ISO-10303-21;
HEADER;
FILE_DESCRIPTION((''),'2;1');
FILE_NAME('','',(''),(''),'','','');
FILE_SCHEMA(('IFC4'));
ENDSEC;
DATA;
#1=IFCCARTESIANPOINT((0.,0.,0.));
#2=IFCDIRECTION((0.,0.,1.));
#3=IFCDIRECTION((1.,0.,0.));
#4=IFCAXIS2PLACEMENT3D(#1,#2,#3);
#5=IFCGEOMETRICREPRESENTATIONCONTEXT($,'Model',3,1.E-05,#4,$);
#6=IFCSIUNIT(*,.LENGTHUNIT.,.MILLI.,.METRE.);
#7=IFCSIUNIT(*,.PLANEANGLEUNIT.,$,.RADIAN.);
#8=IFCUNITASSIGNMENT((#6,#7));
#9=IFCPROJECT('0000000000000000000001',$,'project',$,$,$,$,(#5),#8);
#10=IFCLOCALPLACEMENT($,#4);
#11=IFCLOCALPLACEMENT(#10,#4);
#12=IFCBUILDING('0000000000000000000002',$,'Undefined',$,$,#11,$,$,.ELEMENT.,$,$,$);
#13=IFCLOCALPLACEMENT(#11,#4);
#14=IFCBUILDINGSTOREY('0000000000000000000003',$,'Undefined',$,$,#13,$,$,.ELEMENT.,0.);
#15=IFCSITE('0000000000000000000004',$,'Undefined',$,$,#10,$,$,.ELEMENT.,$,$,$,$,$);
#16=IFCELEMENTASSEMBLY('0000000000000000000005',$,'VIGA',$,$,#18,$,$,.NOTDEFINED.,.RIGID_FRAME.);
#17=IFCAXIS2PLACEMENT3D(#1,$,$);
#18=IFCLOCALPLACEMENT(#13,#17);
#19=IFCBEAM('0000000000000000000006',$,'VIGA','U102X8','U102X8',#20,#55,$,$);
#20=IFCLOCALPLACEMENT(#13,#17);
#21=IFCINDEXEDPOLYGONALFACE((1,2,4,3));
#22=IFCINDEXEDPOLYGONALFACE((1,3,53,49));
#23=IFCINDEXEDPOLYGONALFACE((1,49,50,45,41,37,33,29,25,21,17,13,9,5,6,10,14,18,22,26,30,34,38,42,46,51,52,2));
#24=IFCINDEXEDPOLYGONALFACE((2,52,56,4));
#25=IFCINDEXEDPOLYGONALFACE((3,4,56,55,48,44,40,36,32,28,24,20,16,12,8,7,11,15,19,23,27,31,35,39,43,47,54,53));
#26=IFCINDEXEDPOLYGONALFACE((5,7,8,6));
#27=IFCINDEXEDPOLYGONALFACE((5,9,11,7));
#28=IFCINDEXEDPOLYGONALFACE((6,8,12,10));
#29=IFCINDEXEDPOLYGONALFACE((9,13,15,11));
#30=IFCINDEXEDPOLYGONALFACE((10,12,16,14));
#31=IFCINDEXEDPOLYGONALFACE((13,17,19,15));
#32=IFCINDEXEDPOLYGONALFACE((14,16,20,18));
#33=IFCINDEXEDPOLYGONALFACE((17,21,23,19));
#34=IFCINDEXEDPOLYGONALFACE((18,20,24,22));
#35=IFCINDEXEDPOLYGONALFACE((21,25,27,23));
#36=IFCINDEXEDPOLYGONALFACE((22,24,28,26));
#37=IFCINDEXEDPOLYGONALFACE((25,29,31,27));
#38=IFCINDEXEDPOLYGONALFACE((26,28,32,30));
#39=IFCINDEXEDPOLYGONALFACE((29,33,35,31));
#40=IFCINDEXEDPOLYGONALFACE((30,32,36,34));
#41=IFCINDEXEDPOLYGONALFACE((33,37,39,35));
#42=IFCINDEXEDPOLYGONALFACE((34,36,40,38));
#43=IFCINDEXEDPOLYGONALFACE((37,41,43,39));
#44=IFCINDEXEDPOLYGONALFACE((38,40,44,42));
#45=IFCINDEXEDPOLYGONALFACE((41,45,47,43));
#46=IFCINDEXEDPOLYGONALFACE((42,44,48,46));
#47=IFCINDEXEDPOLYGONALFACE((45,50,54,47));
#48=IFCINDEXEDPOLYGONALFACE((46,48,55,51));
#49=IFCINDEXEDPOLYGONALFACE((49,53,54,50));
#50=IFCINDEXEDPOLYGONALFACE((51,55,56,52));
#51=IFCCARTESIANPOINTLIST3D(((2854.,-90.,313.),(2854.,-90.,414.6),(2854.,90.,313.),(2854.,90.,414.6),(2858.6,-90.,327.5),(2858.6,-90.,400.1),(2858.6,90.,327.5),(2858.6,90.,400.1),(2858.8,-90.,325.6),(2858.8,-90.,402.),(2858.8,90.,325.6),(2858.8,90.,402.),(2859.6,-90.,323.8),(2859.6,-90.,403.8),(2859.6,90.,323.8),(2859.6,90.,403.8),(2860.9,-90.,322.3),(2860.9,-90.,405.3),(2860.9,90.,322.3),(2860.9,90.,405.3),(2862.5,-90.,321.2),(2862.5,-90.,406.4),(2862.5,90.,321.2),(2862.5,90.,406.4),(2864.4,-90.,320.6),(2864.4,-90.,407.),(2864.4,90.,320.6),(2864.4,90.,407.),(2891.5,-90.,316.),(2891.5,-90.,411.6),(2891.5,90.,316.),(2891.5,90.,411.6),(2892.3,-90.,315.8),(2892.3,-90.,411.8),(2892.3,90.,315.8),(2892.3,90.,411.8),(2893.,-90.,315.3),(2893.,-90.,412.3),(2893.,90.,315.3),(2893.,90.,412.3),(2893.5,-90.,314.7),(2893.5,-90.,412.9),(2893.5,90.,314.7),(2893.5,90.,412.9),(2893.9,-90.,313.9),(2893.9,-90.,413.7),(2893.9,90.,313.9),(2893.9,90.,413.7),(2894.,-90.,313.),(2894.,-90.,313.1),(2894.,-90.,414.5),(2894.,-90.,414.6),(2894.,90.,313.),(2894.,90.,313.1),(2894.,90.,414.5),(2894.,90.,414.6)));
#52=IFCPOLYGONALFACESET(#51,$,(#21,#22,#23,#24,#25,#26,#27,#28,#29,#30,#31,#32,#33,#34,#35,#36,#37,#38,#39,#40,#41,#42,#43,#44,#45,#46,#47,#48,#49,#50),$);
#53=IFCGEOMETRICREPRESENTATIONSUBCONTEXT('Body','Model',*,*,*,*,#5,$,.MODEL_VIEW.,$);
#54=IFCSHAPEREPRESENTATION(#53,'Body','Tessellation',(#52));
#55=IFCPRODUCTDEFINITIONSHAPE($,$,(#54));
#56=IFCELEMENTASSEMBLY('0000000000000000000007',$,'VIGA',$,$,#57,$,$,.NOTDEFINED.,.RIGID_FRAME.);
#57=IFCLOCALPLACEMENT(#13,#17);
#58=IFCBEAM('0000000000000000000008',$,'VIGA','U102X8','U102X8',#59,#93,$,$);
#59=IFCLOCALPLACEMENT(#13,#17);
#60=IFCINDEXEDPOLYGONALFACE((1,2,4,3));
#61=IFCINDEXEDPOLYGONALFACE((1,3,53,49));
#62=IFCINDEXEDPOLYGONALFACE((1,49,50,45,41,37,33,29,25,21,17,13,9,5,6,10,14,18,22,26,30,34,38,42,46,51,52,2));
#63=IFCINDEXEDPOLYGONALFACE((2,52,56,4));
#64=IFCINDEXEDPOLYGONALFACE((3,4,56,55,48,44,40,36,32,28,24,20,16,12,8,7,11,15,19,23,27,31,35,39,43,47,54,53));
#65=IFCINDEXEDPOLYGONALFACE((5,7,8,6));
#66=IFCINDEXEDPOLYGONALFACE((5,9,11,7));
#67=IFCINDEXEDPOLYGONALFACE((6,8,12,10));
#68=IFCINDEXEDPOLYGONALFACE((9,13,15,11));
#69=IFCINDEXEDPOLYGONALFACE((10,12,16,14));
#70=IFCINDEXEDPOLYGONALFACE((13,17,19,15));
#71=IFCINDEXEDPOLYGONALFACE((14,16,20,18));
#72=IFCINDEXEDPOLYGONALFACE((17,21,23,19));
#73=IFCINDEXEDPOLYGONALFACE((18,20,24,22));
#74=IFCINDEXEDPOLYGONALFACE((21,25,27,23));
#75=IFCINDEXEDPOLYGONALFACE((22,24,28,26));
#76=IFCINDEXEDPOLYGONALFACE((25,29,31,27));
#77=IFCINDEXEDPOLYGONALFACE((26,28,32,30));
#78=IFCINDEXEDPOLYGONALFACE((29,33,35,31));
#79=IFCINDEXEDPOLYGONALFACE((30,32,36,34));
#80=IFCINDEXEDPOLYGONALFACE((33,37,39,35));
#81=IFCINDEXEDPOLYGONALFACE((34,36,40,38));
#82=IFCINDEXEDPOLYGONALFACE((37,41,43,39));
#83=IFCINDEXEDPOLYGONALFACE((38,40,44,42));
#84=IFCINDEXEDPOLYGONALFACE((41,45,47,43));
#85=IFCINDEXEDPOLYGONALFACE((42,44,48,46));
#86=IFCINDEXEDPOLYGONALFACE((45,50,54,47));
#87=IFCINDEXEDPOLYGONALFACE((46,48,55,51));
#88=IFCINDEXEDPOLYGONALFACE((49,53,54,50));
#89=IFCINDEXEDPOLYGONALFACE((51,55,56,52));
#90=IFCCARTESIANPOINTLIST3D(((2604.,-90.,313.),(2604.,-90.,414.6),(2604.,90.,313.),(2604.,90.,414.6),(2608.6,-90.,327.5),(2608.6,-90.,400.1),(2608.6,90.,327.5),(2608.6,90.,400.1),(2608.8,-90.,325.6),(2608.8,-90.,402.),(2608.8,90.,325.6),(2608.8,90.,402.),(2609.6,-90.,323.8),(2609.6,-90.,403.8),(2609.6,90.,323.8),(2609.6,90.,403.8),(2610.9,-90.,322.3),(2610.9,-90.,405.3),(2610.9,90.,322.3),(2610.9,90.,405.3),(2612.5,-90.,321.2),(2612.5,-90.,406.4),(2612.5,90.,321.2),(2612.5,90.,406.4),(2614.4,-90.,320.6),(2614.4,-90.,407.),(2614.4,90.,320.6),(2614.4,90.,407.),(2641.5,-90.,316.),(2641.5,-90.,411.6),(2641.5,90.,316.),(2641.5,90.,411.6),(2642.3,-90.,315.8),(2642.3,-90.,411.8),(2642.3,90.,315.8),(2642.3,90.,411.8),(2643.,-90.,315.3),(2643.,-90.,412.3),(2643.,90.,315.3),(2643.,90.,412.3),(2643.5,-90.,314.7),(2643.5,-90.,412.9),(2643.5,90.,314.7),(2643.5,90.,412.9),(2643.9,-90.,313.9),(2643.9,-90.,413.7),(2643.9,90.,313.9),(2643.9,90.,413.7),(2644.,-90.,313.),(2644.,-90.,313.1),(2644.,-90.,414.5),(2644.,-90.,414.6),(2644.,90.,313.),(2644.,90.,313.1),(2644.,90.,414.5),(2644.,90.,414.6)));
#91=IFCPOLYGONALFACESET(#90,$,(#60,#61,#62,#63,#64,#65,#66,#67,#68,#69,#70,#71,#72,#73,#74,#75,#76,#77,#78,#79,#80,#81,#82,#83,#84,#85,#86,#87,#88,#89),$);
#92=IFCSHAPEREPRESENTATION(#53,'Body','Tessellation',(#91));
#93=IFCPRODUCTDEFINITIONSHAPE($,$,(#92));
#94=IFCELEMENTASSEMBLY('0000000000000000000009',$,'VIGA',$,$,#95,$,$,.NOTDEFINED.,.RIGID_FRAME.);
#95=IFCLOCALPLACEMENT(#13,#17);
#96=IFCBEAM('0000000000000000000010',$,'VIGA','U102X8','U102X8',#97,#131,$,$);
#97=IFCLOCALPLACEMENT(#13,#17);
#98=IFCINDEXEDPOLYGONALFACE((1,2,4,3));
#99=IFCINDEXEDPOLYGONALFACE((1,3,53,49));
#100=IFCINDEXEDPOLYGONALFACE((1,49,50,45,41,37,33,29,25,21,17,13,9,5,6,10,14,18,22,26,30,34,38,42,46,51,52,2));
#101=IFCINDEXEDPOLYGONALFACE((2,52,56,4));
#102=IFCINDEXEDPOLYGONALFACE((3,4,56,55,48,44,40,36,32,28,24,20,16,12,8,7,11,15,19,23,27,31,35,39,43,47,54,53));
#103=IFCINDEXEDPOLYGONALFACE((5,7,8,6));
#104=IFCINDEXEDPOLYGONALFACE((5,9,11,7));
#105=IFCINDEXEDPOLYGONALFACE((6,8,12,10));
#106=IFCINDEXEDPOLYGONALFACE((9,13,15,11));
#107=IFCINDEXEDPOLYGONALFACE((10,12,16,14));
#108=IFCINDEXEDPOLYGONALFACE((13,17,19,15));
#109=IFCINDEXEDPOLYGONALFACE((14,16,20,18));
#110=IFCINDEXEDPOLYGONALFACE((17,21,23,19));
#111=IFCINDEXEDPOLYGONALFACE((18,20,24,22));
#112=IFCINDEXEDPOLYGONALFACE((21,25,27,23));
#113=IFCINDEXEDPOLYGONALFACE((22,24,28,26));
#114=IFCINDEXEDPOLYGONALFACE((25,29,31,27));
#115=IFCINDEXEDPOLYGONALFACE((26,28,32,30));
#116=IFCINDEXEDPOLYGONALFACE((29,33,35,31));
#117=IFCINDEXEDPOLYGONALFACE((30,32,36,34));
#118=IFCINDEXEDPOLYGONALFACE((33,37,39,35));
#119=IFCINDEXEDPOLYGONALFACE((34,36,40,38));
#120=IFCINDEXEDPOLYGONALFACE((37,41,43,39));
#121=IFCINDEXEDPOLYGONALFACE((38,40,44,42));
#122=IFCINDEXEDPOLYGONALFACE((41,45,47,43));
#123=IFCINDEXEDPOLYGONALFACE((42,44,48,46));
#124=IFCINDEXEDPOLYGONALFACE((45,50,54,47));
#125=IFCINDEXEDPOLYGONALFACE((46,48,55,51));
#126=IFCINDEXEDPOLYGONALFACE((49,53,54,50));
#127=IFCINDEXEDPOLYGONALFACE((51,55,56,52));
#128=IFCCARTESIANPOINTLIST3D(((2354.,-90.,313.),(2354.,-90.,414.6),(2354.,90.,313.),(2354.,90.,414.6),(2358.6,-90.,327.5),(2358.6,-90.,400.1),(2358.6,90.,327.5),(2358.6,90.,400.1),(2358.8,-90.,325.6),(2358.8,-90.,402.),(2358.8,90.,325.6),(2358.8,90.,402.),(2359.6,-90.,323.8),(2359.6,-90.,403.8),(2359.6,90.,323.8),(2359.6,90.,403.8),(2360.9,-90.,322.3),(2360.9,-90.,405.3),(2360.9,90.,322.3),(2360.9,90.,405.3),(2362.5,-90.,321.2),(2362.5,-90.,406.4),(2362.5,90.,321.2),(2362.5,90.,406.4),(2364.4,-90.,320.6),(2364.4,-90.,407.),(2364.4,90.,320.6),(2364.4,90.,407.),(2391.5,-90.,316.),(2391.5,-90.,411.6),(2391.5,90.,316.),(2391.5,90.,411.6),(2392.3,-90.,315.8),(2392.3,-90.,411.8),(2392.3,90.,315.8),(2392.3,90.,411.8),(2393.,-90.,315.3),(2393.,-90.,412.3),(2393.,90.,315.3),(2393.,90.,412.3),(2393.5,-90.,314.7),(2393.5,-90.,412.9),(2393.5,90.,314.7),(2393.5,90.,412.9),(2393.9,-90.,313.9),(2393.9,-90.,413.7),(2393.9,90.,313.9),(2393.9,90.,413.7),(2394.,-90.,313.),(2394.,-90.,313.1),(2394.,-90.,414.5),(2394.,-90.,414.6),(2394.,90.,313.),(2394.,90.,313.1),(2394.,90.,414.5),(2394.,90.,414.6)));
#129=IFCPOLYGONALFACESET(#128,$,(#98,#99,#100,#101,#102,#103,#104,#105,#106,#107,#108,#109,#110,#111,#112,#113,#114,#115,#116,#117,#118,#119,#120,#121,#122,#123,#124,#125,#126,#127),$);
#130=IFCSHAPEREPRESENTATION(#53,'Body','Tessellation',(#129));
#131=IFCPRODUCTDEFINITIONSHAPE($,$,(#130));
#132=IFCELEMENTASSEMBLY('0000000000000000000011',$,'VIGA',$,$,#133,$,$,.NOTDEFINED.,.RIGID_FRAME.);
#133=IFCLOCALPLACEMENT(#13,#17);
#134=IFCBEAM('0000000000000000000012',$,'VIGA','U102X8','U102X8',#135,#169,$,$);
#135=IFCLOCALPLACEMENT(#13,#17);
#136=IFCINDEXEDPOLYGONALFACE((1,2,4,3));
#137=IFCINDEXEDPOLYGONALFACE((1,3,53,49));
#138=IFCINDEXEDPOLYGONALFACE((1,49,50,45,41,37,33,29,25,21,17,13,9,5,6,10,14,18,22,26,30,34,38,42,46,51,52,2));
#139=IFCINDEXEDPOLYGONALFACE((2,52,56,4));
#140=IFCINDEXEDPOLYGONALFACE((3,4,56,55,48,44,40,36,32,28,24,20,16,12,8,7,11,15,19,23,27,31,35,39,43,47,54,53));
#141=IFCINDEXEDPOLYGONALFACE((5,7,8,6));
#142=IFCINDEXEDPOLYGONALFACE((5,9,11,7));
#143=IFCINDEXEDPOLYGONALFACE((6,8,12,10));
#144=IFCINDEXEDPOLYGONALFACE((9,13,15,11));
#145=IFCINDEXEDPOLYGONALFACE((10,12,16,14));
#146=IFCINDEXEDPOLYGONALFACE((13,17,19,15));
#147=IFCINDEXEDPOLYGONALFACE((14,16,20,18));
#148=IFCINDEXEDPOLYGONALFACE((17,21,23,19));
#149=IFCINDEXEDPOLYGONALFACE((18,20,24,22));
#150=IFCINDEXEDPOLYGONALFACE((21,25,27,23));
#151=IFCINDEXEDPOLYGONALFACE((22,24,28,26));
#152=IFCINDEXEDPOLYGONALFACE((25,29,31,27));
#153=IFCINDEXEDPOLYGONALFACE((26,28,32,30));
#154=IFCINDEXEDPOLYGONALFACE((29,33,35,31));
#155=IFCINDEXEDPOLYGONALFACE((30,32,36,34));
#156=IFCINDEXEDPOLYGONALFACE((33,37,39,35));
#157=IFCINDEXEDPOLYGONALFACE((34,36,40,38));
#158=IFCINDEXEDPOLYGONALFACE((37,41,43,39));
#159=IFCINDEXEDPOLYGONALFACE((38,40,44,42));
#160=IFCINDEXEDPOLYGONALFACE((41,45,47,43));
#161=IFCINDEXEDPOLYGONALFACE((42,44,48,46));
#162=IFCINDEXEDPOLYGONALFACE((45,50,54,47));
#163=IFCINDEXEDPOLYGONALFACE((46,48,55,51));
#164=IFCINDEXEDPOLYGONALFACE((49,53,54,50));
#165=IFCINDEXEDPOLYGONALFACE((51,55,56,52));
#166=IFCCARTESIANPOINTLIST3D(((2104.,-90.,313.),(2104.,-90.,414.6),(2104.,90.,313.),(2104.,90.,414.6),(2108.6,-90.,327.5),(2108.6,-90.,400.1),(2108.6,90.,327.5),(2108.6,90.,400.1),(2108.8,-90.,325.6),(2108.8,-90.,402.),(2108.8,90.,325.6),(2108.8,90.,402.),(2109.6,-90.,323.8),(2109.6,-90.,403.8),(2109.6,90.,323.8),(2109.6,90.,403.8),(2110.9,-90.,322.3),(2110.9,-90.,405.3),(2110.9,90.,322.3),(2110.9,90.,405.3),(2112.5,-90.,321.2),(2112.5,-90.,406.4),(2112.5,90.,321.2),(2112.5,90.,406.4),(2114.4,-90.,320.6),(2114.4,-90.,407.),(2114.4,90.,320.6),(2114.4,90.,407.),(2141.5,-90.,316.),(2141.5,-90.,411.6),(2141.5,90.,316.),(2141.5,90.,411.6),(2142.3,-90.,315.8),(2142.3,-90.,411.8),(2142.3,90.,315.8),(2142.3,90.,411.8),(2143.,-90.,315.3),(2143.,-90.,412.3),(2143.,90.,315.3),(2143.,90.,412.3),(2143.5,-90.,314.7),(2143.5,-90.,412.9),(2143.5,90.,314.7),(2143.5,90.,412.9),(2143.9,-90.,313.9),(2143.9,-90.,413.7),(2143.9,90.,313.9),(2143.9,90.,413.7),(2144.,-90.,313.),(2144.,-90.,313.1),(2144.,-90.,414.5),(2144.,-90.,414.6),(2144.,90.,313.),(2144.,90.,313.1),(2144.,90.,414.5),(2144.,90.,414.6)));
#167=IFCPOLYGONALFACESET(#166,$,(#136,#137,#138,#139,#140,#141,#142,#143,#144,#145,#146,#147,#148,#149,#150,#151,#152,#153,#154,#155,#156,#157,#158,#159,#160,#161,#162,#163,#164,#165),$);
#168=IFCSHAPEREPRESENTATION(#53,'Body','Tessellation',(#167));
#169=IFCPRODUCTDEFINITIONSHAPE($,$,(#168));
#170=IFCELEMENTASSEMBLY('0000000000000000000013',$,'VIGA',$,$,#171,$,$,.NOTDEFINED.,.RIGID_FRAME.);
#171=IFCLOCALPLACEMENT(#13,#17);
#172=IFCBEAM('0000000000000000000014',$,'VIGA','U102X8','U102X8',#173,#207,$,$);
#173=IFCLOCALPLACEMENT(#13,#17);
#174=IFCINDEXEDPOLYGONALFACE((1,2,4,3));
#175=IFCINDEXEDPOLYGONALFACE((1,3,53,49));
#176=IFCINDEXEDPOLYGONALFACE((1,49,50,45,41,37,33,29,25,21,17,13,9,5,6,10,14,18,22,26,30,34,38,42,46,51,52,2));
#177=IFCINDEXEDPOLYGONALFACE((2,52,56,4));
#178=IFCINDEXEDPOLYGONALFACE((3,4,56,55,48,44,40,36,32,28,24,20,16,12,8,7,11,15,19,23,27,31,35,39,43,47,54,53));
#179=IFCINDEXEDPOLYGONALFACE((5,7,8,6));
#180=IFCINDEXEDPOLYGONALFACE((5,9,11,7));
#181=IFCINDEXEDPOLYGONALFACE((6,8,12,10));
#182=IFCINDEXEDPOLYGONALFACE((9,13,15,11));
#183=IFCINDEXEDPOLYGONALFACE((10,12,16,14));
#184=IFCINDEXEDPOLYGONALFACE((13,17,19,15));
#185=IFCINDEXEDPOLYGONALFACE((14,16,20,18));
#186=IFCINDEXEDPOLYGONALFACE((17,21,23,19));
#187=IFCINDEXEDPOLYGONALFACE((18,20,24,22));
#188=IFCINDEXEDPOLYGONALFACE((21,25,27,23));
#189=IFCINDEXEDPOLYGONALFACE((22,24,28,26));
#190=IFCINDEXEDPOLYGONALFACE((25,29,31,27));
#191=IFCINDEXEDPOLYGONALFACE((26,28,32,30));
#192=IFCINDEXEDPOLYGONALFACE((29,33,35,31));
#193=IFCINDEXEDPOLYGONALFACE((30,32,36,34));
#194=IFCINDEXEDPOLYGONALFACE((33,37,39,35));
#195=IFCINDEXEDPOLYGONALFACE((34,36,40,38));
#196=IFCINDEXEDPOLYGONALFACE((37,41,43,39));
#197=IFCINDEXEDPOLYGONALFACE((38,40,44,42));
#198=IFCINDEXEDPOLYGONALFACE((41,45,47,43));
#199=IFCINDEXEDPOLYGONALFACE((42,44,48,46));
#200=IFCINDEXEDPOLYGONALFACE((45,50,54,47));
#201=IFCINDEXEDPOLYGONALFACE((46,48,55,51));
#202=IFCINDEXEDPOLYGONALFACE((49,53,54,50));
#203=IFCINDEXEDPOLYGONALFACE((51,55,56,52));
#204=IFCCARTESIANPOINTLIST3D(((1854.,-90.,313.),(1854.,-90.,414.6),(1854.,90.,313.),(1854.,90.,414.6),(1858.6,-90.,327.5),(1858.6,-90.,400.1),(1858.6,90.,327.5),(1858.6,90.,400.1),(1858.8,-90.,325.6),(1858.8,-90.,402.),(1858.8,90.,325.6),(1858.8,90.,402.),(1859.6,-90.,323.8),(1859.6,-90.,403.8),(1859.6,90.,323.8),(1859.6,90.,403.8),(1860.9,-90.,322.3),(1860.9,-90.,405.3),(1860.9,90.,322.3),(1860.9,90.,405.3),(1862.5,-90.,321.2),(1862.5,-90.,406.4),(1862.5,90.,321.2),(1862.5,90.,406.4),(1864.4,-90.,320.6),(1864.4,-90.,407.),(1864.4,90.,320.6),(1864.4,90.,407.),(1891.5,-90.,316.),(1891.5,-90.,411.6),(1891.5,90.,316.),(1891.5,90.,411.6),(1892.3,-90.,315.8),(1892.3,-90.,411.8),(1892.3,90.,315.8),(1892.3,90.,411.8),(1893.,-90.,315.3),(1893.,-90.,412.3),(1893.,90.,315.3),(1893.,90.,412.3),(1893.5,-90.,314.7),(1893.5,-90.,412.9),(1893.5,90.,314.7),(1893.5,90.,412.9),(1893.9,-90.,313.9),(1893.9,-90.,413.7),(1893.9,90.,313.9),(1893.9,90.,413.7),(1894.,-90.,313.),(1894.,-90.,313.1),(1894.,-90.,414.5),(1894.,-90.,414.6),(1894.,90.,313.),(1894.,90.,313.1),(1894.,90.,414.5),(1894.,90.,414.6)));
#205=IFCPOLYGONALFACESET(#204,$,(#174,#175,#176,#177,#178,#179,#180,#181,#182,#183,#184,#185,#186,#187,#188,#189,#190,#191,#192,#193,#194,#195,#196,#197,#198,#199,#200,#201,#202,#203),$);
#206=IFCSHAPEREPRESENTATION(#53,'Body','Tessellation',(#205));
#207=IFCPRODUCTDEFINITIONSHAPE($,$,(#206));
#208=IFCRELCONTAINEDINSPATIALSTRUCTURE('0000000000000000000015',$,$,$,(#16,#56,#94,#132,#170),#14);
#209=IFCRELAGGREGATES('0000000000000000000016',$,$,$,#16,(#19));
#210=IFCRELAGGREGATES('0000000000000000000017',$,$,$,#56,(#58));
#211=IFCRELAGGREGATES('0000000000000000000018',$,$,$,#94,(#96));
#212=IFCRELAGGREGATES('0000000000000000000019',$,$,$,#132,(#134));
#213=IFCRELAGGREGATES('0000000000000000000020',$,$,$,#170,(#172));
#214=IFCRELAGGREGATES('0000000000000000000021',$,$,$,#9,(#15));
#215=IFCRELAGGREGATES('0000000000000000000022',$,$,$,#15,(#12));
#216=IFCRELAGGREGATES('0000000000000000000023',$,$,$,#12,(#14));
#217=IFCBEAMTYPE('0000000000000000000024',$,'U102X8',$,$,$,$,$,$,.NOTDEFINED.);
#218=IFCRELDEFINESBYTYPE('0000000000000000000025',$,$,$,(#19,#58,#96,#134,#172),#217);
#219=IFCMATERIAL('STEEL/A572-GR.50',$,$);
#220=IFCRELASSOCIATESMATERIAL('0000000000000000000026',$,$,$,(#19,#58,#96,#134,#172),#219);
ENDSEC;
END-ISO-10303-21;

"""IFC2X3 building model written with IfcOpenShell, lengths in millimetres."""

from ifc_helpers import new_model, si_unit, frame, origin_with_axes, origin_2d_with_axis, place, context, subcontext, project, spatial, u_section, extrude, material, type_object, element, aggregate, save


model = new_model("IFC2X3")

# Units and contexts
model_context = context("Model", 3, precision=1e-05, world=origin_with_axes())
body_context = subcontext(model_context, "Body", "Model", "MODEL_VIEW")
ifc_project = project(units=[si_unit("LENGTHUNIT", "METRE", prefix="MILLI"), si_unit("PLANEANGLEUNIT", "RADIAN")], contexts=[model_context])

# Site, building, storey
site_placement = place(None, origin_with_axes())
site = spatial("IfcSite", under=ifc_project, at=site_placement, Name="Undefined", CompositionType="ELEMENT")
building_placement = place(site_placement, origin_with_axes())
building = spatial("IfcBuilding", under=site, at=building_placement, Name="Undefined", CompositionType="ELEMENT")
storey_placement = place(building_placement, origin_with_axes())
storey = spatial("IfcBuildingStorey", under=building, at=storey_placement, Name="Undefined", CompositionType="ELEMENT", Elevation=0.0)

# Element assemblies, beams
ifc_material = material(Name="STEEL/A572-GR.50")
beam_type = type_object("IfcBeamType", Name="U102X8", PredefinedType="NOTDEFINED")
assembly_1_placement = place(storey_placement, origin_with_axes())
assembly_1 = element("IfcElementAssembly", 1, at=assembly_1_placement, inside=storey, Name="VIGA", AssemblyPlace="NOTDEFINED", PredefinedType="RIGID_FRAME")
beam_1_placement = place(assembly_1_placement, frame((2874.0, -90.0, 363.8), z_axis=(0.0, 0.0, 1.0), x_axis=(0.0, 1.0, 0.0)))
beam_1 = element("IfcBeam", 2, at=beam_1_placement, type_object=beam_type, material=ifc_material, Name="VIGA", Description="U102X8", ObjectType="U102X8", context=body_context, shape_type="SweptSolid", body=[
    extrude(u_section(Depth=101.6, FlangeWidth=40.0, WebThickness=4.6, FlangeThickness=6.0, FilletRadius=7.0, EdgeRadius=3.0, FlangeSlope=0.16839, at=origin_2d_with_axis()), frame((180.0, 0.0, 0.0), z_axis=(-1.0, 0.0, 0.0), x_axis=(0.0, -1.0, 0.0)), (0.0, 0.0, 1.0), 180.0),
])
aggregate(assembly_1, [beam_1])
assembly_2_placement = place(storey_placement, origin_with_axes())
assembly_2 = element("IfcElementAssembly", 3, at=assembly_2_placement, inside=storey, Name="VIGA", AssemblyPlace="NOTDEFINED", PredefinedType="RIGID_FRAME")
beam_2_placement = place(assembly_2_placement, frame((2624.0, -90.0, 363.8), z_axis=(0.0, 0.0, 1.0), x_axis=(0.0, 1.0, 0.0)))
beam_2 = element("IfcBeam", 4, at=beam_2_placement, type_object=beam_type, material=ifc_material, Name="VIGA", Description="U102X8", ObjectType="U102X8", context=body_context, shape_type="SweptSolid", body=[
    extrude(u_section(Depth=101.6, FlangeWidth=40.0, WebThickness=4.6, FlangeThickness=6.0, FilletRadius=7.0, EdgeRadius=3.0, FlangeSlope=0.16839, at=origin_2d_with_axis()), frame((180.0, 0.0, 0.0), z_axis=(-1.0, 0.0, 0.0), x_axis=(0.0, -1.0, 0.0)), (0.0, 0.0, 1.0), 180.0),
])
aggregate(assembly_2, [beam_2])
assembly_3_placement = place(storey_placement, origin_with_axes())
assembly_3 = element("IfcElementAssembly", 5, at=assembly_3_placement, inside=storey, Name="VIGA", AssemblyPlace="NOTDEFINED", PredefinedType="RIGID_FRAME")
beam_3_placement = place(assembly_3_placement, frame((2374.0, -90.0, 363.8), z_axis=(0.0, 0.0, 1.0), x_axis=(0.0, 1.0, 0.0)))
beam_3 = element("IfcBeam", 6, at=beam_3_placement, type_object=beam_type, material=ifc_material, Name="VIGA", Description="U102X8", ObjectType="U102X8", context=body_context, shape_type="SweptSolid", body=[
    extrude(u_section(Depth=101.6, FlangeWidth=40.0, WebThickness=4.6, FlangeThickness=6.0, FilletRadius=7.0, EdgeRadius=3.0, FlangeSlope=0.16839, at=origin_2d_with_axis()), frame((180.0, 0.0, 0.0), z_axis=(-1.0, 0.0, 0.0), x_axis=(0.0, -1.0, 0.0)), (0.0, 0.0, 1.0), 180.0),
])
aggregate(assembly_3, [beam_3])
assembly_4_placement = place(storey_placement, origin_with_axes())
assembly_4 = element("IfcElementAssembly", 7, at=assembly_4_placement, inside=storey, Name="VIGA", AssemblyPlace="NOTDEFINED", PredefinedType="RIGID_FRAME")
beam_4_placement = place(assembly_4_placement, frame((2124.0, -90.0, 363.8), z_axis=(0.0, 0.0, 1.0), x_axis=(0.0, 1.0, 0.0)))
beam_4 = element("IfcBeam", 8, at=beam_4_placement, type_object=beam_type, material=ifc_material, Name="VIGA", Description="U102X8", ObjectType="U102X8", context=body_context, shape_type="SweptSolid", body=[
    extrude(u_section(Depth=101.6, FlangeWidth=40.0, WebThickness=4.6, FlangeThickness=6.0, FilletRadius=7.0, EdgeRadius=3.0, FlangeSlope=0.16839, at=origin_2d_with_axis()), frame((180.0, 0.0, 0.0), z_axis=(-1.0, 0.0, 0.0), x_axis=(0.0, -1.0, 0.0)), (0.0, 0.0, 1.0), 180.0),
])
aggregate(assembly_4, [beam_4])
assembly_5_placement = place(storey_placement, origin_with_axes())
assembly_5 = element("IfcElementAssembly", 9, at=assembly_5_placement, inside=storey, Name="VIGA", AssemblyPlace="NOTDEFINED", PredefinedType="RIGID_FRAME")
beam_5_placement = place(assembly_5_placement, frame((1874.0, -90.0, 363.8), z_axis=(0.0, 0.0, 1.0), x_axis=(0.0, 1.0, 0.0)))
beam_5 = element("IfcBeam", 10, at=beam_5_placement, type_object=beam_type, material=ifc_material, Name="VIGA", Description="U102X8", ObjectType="U102X8", context=body_context, shape_type="SweptSolid", body=[
    extrude(u_section(Depth=101.6, FlangeWidth=40.0, WebThickness=4.6, FlangeThickness=6.0, FilletRadius=7.0, EdgeRadius=3.0, FlangeSlope=0.16839, at=origin_2d_with_axis()), frame((180.0, 0.0, 0.0), z_axis=(-1.0, 0.0, 0.0), x_axis=(0.0, -1.0, 0.0)), (0.0, 0.0, 1.0), 180.0),
])
aggregate(assembly_5, [beam_5])

save(model, "model.ifc")
